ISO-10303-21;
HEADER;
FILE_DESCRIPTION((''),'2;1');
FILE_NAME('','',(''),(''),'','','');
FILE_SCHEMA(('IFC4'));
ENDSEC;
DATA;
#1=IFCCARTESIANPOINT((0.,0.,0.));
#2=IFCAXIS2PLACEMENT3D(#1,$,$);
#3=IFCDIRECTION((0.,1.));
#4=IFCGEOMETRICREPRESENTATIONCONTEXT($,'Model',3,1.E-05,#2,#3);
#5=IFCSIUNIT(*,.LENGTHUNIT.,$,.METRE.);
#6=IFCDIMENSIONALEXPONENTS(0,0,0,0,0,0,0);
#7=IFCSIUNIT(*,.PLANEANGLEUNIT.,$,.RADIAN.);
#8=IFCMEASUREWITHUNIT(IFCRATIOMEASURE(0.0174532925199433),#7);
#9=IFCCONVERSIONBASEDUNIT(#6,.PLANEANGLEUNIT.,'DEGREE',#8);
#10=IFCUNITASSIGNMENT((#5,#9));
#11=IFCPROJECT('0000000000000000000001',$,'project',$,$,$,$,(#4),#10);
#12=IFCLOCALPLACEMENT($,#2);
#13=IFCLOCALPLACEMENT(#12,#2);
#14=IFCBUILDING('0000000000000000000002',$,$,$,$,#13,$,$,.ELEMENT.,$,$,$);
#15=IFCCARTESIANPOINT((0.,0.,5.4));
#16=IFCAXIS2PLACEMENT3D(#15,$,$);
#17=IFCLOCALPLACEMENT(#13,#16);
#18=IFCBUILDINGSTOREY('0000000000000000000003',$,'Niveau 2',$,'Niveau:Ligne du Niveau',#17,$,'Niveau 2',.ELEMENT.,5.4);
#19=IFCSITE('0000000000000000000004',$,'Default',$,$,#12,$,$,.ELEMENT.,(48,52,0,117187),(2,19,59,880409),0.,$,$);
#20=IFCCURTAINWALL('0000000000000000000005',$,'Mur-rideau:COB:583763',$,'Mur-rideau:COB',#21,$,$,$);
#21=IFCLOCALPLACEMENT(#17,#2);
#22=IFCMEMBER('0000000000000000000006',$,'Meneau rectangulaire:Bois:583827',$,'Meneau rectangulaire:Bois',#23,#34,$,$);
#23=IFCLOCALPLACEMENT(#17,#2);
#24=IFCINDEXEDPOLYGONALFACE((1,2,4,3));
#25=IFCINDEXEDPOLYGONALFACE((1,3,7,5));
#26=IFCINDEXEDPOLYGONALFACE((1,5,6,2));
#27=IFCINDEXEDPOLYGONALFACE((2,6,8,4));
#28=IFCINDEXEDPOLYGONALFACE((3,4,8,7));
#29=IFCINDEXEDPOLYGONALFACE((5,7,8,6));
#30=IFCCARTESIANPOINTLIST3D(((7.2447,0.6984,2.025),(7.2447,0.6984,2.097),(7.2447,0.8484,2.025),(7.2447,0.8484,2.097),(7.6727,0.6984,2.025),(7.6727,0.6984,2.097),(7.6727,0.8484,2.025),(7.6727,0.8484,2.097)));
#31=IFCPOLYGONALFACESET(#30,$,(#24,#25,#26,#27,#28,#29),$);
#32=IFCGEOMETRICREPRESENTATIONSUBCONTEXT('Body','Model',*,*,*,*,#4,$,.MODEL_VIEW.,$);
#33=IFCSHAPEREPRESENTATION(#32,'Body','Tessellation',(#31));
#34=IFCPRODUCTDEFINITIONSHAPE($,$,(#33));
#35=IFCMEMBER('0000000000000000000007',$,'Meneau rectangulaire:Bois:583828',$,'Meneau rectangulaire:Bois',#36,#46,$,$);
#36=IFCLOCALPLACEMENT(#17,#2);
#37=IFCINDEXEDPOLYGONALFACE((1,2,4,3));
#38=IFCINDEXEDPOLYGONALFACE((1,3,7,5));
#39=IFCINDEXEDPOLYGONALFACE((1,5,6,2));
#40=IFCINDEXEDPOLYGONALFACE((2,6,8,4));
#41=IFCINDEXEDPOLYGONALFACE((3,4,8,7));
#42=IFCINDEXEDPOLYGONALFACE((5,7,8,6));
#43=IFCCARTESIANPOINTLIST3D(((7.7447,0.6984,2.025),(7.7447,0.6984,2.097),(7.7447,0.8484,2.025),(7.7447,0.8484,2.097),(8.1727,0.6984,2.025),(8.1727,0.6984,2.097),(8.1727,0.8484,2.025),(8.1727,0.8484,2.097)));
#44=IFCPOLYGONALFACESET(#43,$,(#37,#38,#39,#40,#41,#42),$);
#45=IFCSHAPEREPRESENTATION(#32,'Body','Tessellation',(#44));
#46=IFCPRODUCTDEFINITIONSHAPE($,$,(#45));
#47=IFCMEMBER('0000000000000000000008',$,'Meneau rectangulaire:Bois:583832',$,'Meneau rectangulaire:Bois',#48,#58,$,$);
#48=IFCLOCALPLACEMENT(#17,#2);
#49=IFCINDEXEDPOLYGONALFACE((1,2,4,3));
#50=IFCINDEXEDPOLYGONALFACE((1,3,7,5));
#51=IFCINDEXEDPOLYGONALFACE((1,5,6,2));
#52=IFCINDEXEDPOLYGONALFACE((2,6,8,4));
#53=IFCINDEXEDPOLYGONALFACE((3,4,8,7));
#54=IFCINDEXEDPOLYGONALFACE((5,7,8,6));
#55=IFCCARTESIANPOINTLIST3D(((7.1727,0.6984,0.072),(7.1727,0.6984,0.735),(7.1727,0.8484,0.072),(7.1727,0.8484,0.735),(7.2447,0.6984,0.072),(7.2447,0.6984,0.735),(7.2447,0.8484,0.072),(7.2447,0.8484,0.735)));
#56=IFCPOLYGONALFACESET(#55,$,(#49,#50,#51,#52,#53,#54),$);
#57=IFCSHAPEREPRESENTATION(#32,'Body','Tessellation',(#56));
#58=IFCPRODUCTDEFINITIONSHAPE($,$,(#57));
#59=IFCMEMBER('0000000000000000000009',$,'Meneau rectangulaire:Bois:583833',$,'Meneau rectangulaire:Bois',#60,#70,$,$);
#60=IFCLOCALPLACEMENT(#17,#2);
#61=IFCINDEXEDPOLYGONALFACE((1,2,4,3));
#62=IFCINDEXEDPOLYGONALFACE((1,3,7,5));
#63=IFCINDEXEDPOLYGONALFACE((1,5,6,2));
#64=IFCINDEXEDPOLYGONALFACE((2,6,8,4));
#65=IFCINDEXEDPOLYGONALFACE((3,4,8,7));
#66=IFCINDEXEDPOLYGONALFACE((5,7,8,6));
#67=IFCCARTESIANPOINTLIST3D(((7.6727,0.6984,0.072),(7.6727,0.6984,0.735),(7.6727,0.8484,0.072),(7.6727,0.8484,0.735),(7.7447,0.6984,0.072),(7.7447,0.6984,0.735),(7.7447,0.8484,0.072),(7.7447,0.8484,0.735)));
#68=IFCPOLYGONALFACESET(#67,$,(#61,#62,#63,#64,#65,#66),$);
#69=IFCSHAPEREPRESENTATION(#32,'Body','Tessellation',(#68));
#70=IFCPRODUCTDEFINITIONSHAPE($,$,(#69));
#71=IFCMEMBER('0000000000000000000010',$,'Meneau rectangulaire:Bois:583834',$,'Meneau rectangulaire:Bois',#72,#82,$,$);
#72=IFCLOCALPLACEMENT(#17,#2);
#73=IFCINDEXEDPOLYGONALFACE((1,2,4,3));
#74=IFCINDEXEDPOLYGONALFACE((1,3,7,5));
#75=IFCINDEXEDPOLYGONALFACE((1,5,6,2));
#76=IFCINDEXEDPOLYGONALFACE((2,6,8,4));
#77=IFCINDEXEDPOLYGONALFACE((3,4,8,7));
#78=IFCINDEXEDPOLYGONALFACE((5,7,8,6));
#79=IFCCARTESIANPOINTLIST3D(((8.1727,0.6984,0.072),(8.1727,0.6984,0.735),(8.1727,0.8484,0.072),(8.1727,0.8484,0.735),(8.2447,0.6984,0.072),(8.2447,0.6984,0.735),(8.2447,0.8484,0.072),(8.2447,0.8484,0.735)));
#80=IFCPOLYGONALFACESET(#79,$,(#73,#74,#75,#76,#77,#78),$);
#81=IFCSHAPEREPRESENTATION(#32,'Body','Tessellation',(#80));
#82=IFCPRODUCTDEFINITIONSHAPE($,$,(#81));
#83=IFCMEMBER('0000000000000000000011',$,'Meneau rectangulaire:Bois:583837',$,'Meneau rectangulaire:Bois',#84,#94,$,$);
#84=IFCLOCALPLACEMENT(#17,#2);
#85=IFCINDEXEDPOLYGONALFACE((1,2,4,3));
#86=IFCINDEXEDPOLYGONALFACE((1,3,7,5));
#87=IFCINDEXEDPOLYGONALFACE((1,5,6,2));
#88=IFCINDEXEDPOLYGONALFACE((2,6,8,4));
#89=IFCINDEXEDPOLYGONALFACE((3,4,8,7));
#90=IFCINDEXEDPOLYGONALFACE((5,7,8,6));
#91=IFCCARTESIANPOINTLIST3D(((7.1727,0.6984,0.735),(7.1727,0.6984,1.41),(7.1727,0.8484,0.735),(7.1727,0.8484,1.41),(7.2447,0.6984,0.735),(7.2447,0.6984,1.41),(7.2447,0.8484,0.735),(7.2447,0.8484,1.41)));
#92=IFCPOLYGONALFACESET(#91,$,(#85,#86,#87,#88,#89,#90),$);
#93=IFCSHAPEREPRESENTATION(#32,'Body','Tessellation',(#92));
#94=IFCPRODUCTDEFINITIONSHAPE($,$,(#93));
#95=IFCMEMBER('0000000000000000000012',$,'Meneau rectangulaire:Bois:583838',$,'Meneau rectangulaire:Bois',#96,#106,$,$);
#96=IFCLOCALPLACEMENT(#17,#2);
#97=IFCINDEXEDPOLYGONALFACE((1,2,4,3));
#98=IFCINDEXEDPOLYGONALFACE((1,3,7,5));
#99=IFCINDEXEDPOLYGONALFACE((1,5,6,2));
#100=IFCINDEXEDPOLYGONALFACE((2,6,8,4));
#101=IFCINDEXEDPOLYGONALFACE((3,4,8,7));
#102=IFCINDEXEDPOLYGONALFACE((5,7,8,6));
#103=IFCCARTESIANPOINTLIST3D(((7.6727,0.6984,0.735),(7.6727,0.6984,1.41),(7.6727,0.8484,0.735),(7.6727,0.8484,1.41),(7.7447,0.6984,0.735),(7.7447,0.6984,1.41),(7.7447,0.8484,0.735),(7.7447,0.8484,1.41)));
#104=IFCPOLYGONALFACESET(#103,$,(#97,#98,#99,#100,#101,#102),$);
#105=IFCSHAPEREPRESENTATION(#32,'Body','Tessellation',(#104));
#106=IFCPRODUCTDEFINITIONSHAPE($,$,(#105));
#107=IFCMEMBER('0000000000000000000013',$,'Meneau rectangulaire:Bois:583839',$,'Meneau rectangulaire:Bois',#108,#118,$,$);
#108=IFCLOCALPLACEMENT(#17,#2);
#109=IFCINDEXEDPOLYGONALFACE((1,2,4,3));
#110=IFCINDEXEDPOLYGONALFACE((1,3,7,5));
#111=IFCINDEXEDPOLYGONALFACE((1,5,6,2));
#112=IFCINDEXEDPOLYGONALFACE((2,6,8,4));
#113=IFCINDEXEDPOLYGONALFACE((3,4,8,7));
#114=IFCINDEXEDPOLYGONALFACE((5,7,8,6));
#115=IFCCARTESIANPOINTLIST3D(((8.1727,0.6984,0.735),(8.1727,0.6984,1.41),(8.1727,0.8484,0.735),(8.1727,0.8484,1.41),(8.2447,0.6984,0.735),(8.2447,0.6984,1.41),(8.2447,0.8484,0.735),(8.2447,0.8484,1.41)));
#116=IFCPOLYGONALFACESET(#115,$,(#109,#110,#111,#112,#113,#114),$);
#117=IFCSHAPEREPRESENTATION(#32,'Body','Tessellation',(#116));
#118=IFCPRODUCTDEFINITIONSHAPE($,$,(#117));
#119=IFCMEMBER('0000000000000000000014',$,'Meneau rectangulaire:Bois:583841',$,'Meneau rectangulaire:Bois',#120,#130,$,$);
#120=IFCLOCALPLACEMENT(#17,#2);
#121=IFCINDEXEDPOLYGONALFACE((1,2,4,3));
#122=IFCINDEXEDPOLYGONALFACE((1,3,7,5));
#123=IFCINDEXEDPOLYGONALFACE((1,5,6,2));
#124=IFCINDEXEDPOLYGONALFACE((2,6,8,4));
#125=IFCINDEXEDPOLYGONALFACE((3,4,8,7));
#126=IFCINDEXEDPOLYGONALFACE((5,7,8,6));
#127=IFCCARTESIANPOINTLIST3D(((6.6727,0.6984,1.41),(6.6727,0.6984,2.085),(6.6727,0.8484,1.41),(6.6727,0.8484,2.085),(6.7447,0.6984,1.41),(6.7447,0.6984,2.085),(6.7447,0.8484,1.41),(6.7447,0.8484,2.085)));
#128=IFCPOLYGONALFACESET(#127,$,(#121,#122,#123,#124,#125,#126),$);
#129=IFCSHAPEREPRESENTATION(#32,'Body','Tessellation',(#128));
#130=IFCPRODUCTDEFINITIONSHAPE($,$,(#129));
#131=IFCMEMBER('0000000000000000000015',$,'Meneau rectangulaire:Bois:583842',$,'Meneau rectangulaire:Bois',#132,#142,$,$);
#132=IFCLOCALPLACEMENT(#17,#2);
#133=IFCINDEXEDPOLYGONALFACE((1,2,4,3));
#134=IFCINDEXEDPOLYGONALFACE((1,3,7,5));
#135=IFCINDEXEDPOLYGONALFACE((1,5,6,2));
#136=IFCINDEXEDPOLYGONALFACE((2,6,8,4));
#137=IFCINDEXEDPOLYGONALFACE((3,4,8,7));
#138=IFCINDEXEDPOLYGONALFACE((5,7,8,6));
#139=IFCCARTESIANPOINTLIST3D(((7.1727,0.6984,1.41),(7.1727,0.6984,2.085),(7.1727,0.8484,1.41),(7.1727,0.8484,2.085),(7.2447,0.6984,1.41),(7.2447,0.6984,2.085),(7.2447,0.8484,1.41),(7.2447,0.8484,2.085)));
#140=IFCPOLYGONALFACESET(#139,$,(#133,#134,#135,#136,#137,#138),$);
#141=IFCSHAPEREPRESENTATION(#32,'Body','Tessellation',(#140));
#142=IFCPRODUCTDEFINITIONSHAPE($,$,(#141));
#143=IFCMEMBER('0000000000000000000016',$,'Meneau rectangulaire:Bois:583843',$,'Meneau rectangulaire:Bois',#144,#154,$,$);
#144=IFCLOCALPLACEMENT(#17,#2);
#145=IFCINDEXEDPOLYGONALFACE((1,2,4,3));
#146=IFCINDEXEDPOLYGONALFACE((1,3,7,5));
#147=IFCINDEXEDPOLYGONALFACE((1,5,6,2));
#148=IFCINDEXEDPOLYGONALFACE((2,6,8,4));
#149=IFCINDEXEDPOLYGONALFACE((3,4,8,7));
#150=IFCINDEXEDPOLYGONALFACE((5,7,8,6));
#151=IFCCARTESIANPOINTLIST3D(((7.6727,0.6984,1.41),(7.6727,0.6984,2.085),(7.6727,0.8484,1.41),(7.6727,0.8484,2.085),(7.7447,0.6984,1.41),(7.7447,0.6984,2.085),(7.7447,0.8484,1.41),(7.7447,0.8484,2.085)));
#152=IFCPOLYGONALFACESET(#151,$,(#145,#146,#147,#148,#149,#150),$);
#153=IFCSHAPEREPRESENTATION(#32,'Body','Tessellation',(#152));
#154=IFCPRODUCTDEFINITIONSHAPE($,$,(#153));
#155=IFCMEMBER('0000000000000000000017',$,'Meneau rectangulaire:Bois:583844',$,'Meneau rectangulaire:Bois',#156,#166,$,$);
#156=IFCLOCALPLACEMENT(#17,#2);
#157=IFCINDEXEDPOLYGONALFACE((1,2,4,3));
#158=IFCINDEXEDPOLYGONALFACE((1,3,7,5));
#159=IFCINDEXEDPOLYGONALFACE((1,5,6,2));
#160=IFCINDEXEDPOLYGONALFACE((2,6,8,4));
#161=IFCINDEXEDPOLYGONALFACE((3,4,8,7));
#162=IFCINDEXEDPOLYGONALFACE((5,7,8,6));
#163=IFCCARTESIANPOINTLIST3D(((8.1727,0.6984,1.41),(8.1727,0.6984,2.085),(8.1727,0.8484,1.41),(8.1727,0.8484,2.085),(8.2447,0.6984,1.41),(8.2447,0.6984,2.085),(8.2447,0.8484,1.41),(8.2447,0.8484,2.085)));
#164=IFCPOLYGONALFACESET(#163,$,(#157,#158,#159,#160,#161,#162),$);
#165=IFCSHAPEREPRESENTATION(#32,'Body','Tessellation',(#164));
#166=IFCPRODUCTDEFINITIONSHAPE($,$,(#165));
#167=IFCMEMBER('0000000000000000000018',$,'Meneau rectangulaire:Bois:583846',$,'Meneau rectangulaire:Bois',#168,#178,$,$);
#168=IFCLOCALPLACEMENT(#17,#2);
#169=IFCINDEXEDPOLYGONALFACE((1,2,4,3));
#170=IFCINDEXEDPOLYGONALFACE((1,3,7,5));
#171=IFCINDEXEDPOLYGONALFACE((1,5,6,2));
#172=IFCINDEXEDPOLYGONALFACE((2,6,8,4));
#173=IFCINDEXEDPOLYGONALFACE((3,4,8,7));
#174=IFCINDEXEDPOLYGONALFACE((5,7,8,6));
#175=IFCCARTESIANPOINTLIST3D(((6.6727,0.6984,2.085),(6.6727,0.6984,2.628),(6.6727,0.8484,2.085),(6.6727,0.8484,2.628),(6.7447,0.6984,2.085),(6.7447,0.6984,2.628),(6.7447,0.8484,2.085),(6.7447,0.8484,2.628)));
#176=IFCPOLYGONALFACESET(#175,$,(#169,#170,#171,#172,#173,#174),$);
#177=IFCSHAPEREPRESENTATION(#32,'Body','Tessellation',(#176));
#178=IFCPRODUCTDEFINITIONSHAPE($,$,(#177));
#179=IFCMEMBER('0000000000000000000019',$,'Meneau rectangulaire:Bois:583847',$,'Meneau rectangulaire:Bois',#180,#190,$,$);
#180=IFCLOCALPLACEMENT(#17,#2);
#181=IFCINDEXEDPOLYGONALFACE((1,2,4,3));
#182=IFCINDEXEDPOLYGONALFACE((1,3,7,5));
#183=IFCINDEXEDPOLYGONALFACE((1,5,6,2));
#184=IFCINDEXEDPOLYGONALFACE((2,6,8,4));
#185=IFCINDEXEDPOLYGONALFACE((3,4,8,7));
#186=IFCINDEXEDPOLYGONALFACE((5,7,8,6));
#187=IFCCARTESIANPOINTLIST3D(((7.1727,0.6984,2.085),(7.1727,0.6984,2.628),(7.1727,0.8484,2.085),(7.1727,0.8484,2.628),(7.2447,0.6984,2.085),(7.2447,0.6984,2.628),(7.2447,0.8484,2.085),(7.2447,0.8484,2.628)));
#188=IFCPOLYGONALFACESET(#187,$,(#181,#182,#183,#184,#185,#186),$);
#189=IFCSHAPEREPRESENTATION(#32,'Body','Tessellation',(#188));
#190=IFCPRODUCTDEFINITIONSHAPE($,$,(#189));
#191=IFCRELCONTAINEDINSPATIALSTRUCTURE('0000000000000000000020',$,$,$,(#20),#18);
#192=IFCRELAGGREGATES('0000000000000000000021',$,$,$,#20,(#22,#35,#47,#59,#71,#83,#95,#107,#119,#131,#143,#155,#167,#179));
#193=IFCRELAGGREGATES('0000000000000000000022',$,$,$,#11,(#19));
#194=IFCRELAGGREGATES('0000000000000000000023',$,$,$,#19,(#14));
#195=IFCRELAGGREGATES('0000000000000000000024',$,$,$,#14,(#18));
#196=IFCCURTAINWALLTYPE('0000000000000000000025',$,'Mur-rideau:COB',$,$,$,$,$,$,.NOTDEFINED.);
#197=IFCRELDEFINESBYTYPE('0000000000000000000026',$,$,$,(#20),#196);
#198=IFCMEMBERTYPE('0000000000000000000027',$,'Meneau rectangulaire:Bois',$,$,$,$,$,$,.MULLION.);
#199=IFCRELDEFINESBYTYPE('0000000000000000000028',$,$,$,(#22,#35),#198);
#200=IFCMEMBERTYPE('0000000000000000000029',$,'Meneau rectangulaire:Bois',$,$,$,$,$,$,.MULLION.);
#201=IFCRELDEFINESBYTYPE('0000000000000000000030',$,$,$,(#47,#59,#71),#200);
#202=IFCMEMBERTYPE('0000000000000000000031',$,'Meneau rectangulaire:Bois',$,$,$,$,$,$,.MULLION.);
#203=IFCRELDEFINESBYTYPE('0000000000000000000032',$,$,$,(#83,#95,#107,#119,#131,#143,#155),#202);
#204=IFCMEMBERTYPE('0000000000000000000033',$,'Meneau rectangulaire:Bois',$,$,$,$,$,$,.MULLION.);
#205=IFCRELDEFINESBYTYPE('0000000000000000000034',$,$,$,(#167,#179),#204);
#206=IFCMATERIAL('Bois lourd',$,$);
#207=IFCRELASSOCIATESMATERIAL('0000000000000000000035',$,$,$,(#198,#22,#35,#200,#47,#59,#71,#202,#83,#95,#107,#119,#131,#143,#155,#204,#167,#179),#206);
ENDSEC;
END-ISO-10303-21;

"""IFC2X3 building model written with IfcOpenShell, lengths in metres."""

from ifc_helpers import new_model, entity, si_unit, converted_unit, direction, frame, origin, origin_2d_with_axis, place, context, subcontext, project, spatial, rectangle, extrude, source, transform, mapped, material, type_object, type_shapes, element, aggregate, save


model = new_model("IFC2X3")

# Units and contexts
model_context = context("Model", 3, precision=1e-05, world=origin(), true_north=direction((0.0, 1.0)))
body_context = subcontext(model_context, "Body", "Model", "MODEL_VIEW")
ifc_project = project(units=[si_unit("LENGTHUNIT", "METRE"), converted_unit("PLANEANGLEUNIT", "DEGREE", entity("IfcRatioMeasure", 0.0174532925199433), si_unit("PLANEANGLEUNIT", "RADIAN"), dimensions=[0, 0, 0, 0, 0, 0, 0])], contexts=[model_context])

# Site, building, storey
site_placement = place(None, origin())
site = spatial("IfcSite", under=ifc_project, at=site_placement, Name="Default", CompositionType="ELEMENT", RefLatitude=(48, 52, 0, 117187), RefLongitude=(2, 19, 59, 880409), RefElevation=0.0)
building_placement = place(site_placement, origin())
building = spatial("IfcBuilding", under=site, at=building_placement, CompositionType="ELEMENT")
storey_placement = place(building_placement, frame((0.0, 0.0, 5.4)))
storey = spatial("IfcBuildingStorey", under=building, at=storey_placement, Name="Niveau 2", ObjectType="Niveau:Ligne du Niveau", LongName="Niveau 2", CompositionType="ELEMENT", Elevation=5.4)

# Curtain wall, members
curtain_wall_type_1 = type_object("IfcCurtainWallType", Name="Mur-rideau:COB", PredefinedType="NOTDEFINED")
curtain_wall_1_placement = place(storey_placement, frame((0.0, 0.0, -5.4)))
curtain_wall_1 = element("IfcCurtainWall", 1, at=curtain_wall_1_placement, inside=storey, type_object=curtain_wall_type_1, Name="Mur-rideau:COB:583763", ObjectType="Mur-rideau:COB")
ifc_material_1 = material(Name="Bois lourd")
member_type_1 = type_object("IfcMemberType", Name="Meneau rectangulaire:Bois", PredefinedType="MULLION", material=ifc_material_1)
shared_shape_1 = source(origin(), body_context, "Body", "SweptSolid", [
    extrude(rectangle(XDim=0.15, YDim=0.072, at=origin_2d_with_axis()), frame((-0.024, 0.0, -0.428), z_axis=(0.0, 0.0, 1.0), x_axis=(0.0, -1.0, 0.0)), (0.0, 0.0, 1.0), 0.428),
])
type_shapes(member_type_1, [shared_shape_1])
member_1_placement = place(storey_placement, frame((7.6727, 0.7734, 2.085), z_axis=(1.0, 0.0, 0.0), x_axis=(0.0, 0.0, 1.0)))
member_1 = element("IfcMember", 2, at=member_1_placement, type_object=member_type_1, material=ifc_material_1, Name="Meneau rectangulaire:Bois:583827", ObjectType="Meneau rectangulaire:Bois", context=body_context, shape_type="MappedRepresentation", body=[
    mapped(shared_shape_1, transform((0.0, 0.0, 0.0), scale=1.0)),
])
member_2_placement = place(storey_placement, frame((8.1727, 0.7734, 2.085), z_axis=(1.0, 0.0, 0.0), x_axis=(0.0, 0.0, 1.0)))
member_2 = element("IfcMember", 3, at=member_2_placement, type_object=member_type_1, material=ifc_material_1, Name="Meneau rectangulaire:Bois:583828", ObjectType="Meneau rectangulaire:Bois", context=body_context, shape_type="MappedRepresentation", body=[
    mapped(shared_shape_1, transform((0.0, 0.0, 0.0), scale=1.0)),
])
member_type_2 = type_object("IfcMemberType", Name="Meneau rectangulaire:Bois", PredefinedType="MULLION", material=ifc_material_1)
shared_shape_2 = source(origin(), body_context, "Body", "SweptSolid", [
    extrude(rectangle(XDim=0.15, YDim=0.072, at=origin_2d_with_axis()), frame((-0.024, 0.0, -0.663), z_axis=(0.0, 0.0, 1.0), x_axis=(0.0, -1.0, 0.0)), (0.0, 0.0, 1.0), 0.663),
])
type_shapes(member_type_2, [shared_shape_2])
member_3_placement = place(storey_placement, frame((7.2327, 0.7734, 0.072), z_axis=(0.0, 0.0, -1.0), x_axis=(1.0, 0.0, 0.0)))
member_3 = element("IfcMember", 4, at=member_3_placement, type_object=member_type_2, material=ifc_material_1, Name="Meneau rectangulaire:Bois:583832", ObjectType="Meneau rectangulaire:Bois", context=body_context, shape_type="MappedRepresentation", body=[
    mapped(shared_shape_2, transform((0.0, 0.0, 0.0), scale=1.0)),
])
member_4_placement = place(storey_placement, frame((7.7327, 0.7734, 0.072), z_axis=(0.0, 0.0, -1.0), x_axis=(1.0, 0.0, 0.0)))
member_4 = element("IfcMember", 5, at=member_4_placement, type_object=member_type_2, material=ifc_material_1, Name="Meneau rectangulaire:Bois:583833", ObjectType="Meneau rectangulaire:Bois", context=body_context, shape_type="MappedRepresentation", body=[
    mapped(shared_shape_2, transform((0.0, 0.0, 0.0), scale=1.0)),
])
member_5_placement = place(storey_placement, frame((8.2327, 0.7734, 0.072), z_axis=(0.0, 0.0, -1.0), x_axis=(1.0, 0.0, 0.0)))
member_5 = element("IfcMember", 6, at=member_5_placement, type_object=member_type_2, material=ifc_material_1, Name="Meneau rectangulaire:Bois:583834", ObjectType="Meneau rectangulaire:Bois", context=body_context, shape_type="MappedRepresentation", body=[
    mapped(shared_shape_2, transform((0.0, 0.0, 0.0), scale=1.0)),
])
member_type_3 = type_object("IfcMemberType", Name="Meneau rectangulaire:Bois", PredefinedType="MULLION", material=ifc_material_1)
shared_shape_3 = source(origin(), body_context, "Body", "SweptSolid", [
    extrude(rectangle(XDim=0.15, YDim=0.072, at=origin_2d_with_axis()), frame((-0.024, 0.0, -0.675), z_axis=(0.0, 0.0, 1.0), x_axis=(0.0, -1.0, 0.0)), (0.0, 0.0, 1.0), 0.675),
])
type_shapes(member_type_3, [shared_shape_3])
member_6_placement = place(storey_placement, frame((7.2327, 0.7734, 0.735), z_axis=(0.0, 0.0, -1.0), x_axis=(1.0, 0.0, 0.0)))
member_6 = element("IfcMember", 7, at=member_6_placement, type_object=member_type_3, material=ifc_material_1, Name="Meneau rectangulaire:Bois:583837", ObjectType="Meneau rectangulaire:Bois", context=body_context, shape_type="MappedRepresentation", body=[
    mapped(shared_shape_3, transform((0.0, 0.0, 0.0), scale=1.0)),
])
member_7_placement = place(storey_placement, frame((7.7327, 0.7734, 0.735), z_axis=(0.0, 0.0, -1.0), x_axis=(1.0, 0.0, 0.0)))
member_7 = element("IfcMember", 8, at=member_7_placement, type_object=member_type_3, material=ifc_material_1, Name="Meneau rectangulaire:Bois:583838", ObjectType="Meneau rectangulaire:Bois", context=body_context, shape_type="MappedRepresentation", body=[
    mapped(shared_shape_3, transform((0.0, 0.0, 0.0), scale=1.0)),
])
member_8_placement = place(storey_placement, frame((8.2327, 0.7734, 0.735), z_axis=(0.0, 0.0, -1.0), x_axis=(1.0, 0.0, 0.0)))
member_8 = element("IfcMember", 9, at=member_8_placement, type_object=member_type_3, material=ifc_material_1, Name="Meneau rectangulaire:Bois:583839", ObjectType="Meneau rectangulaire:Bois", context=body_context, shape_type="MappedRepresentation", body=[
    mapped(shared_shape_3, transform((0.0, 0.0, 0.0), scale=1.0)),
])
member_9_placement = place(storey_placement, frame((6.7327, 0.7734, 1.41), z_axis=(0.0, 0.0, -1.0), x_axis=(1.0, 0.0, 0.0)))
member_9 = element("IfcMember", 10, at=member_9_placement, type_object=member_type_3, material=ifc_material_1, Name="Meneau rectangulaire:Bois:583841", ObjectType="Meneau rectangulaire:Bois", context=body_context, shape_type="MappedRepresentation", body=[
    mapped(shared_shape_3, transform((0.0, 0.0, 0.0), scale=1.0)),
])
member_10_placement = place(storey_placement, frame((7.2327, 0.7734, 1.41), z_axis=(0.0, 0.0, -1.0), x_axis=(1.0, 0.0, 0.0)))
member_10 = element("IfcMember", 11, at=member_10_placement, type_object=member_type_3, material=ifc_material_1, Name="Meneau rectangulaire:Bois:583842", ObjectType="Meneau rectangulaire:Bois", context=body_context, shape_type="MappedRepresentation", body=[
    mapped(shared_shape_3, transform((0.0, 0.0, 0.0), scale=1.0)),
])
member_11_placement = place(storey_placement, frame((7.7327, 0.7734, 1.41), z_axis=(0.0, 0.0, -1.0), x_axis=(1.0, 0.0, 0.0)))
member_11 = element("IfcMember", 12, at=member_11_placement, type_object=member_type_3, material=ifc_material_1, Name="Meneau rectangulaire:Bois:583843", ObjectType="Meneau rectangulaire:Bois", context=body_context, shape_type="MappedRepresentation", body=[
    mapped(shared_shape_3, transform((0.0, 0.0, 0.0), scale=1.0)),
])
member_12_placement = place(storey_placement, frame((8.2327, 0.7734, 1.41), z_axis=(0.0, 0.0, -1.0), x_axis=(1.0, 0.0, 0.0)))
member_12 = element("IfcMember", 13, at=member_12_placement, type_object=member_type_3, material=ifc_material_1, Name="Meneau rectangulaire:Bois:583844", ObjectType="Meneau rectangulaire:Bois", context=body_context, shape_type="MappedRepresentation", body=[
    mapped(shared_shape_3, transform((0.0, 0.0, 0.0), scale=1.0)),
])
member_type_4 = type_object("IfcMemberType", Name="Meneau rectangulaire:Bois", PredefinedType="MULLION", material=ifc_material_1)
shared_shape_4 = source(origin(), body_context, "Body", "SweptSolid", [
    extrude(rectangle(XDim=0.15, YDim=0.072, at=origin_2d_with_axis()), frame((-0.024, 0.0, -0.543), z_axis=(0.0, 0.0, 1.0), x_axis=(0.0, -1.0, 0.0)), (0.0, 0.0, 1.0), 0.543),
])
type_shapes(member_type_4, [shared_shape_4])
member_13_placement = place(storey_placement, frame((6.7327, 0.7734, 2.085), z_axis=(0.0, 0.0, -1.0), x_axis=(1.0, 0.0, 0.0)))
member_13 = element("IfcMember", 14, at=member_13_placement, type_object=member_type_4, material=ifc_material_1, Name="Meneau rectangulaire:Bois:583846", ObjectType="Meneau rectangulaire:Bois", context=body_context, shape_type="MappedRepresentation", body=[
    mapped(shared_shape_4, transform((0.0, 0.0, 0.0), scale=1.0)),
])
member_14_placement = place(storey_placement, frame((7.2327, 0.7734, 2.085), z_axis=(0.0, 0.0, -1.0), x_axis=(1.0, 0.0, 0.0)))
member_14 = element("IfcMember", 15, at=member_14_placement, type_object=member_type_4, material=ifc_material_1, Name="Meneau rectangulaire:Bois:583847", ObjectType="Meneau rectangulaire:Bois", context=body_context, shape_type="MappedRepresentation", body=[
    mapped(shared_shape_4, transform((0.0, 0.0, 0.0), scale=1.0)),
])
aggregate(curtain_wall_1, [member_1, member_2, member_3, member_4, member_5, member_6, member_7, member_8, member_9, member_10, member_11, member_12, member_13, member_14])

save(model, "model.ifc")
